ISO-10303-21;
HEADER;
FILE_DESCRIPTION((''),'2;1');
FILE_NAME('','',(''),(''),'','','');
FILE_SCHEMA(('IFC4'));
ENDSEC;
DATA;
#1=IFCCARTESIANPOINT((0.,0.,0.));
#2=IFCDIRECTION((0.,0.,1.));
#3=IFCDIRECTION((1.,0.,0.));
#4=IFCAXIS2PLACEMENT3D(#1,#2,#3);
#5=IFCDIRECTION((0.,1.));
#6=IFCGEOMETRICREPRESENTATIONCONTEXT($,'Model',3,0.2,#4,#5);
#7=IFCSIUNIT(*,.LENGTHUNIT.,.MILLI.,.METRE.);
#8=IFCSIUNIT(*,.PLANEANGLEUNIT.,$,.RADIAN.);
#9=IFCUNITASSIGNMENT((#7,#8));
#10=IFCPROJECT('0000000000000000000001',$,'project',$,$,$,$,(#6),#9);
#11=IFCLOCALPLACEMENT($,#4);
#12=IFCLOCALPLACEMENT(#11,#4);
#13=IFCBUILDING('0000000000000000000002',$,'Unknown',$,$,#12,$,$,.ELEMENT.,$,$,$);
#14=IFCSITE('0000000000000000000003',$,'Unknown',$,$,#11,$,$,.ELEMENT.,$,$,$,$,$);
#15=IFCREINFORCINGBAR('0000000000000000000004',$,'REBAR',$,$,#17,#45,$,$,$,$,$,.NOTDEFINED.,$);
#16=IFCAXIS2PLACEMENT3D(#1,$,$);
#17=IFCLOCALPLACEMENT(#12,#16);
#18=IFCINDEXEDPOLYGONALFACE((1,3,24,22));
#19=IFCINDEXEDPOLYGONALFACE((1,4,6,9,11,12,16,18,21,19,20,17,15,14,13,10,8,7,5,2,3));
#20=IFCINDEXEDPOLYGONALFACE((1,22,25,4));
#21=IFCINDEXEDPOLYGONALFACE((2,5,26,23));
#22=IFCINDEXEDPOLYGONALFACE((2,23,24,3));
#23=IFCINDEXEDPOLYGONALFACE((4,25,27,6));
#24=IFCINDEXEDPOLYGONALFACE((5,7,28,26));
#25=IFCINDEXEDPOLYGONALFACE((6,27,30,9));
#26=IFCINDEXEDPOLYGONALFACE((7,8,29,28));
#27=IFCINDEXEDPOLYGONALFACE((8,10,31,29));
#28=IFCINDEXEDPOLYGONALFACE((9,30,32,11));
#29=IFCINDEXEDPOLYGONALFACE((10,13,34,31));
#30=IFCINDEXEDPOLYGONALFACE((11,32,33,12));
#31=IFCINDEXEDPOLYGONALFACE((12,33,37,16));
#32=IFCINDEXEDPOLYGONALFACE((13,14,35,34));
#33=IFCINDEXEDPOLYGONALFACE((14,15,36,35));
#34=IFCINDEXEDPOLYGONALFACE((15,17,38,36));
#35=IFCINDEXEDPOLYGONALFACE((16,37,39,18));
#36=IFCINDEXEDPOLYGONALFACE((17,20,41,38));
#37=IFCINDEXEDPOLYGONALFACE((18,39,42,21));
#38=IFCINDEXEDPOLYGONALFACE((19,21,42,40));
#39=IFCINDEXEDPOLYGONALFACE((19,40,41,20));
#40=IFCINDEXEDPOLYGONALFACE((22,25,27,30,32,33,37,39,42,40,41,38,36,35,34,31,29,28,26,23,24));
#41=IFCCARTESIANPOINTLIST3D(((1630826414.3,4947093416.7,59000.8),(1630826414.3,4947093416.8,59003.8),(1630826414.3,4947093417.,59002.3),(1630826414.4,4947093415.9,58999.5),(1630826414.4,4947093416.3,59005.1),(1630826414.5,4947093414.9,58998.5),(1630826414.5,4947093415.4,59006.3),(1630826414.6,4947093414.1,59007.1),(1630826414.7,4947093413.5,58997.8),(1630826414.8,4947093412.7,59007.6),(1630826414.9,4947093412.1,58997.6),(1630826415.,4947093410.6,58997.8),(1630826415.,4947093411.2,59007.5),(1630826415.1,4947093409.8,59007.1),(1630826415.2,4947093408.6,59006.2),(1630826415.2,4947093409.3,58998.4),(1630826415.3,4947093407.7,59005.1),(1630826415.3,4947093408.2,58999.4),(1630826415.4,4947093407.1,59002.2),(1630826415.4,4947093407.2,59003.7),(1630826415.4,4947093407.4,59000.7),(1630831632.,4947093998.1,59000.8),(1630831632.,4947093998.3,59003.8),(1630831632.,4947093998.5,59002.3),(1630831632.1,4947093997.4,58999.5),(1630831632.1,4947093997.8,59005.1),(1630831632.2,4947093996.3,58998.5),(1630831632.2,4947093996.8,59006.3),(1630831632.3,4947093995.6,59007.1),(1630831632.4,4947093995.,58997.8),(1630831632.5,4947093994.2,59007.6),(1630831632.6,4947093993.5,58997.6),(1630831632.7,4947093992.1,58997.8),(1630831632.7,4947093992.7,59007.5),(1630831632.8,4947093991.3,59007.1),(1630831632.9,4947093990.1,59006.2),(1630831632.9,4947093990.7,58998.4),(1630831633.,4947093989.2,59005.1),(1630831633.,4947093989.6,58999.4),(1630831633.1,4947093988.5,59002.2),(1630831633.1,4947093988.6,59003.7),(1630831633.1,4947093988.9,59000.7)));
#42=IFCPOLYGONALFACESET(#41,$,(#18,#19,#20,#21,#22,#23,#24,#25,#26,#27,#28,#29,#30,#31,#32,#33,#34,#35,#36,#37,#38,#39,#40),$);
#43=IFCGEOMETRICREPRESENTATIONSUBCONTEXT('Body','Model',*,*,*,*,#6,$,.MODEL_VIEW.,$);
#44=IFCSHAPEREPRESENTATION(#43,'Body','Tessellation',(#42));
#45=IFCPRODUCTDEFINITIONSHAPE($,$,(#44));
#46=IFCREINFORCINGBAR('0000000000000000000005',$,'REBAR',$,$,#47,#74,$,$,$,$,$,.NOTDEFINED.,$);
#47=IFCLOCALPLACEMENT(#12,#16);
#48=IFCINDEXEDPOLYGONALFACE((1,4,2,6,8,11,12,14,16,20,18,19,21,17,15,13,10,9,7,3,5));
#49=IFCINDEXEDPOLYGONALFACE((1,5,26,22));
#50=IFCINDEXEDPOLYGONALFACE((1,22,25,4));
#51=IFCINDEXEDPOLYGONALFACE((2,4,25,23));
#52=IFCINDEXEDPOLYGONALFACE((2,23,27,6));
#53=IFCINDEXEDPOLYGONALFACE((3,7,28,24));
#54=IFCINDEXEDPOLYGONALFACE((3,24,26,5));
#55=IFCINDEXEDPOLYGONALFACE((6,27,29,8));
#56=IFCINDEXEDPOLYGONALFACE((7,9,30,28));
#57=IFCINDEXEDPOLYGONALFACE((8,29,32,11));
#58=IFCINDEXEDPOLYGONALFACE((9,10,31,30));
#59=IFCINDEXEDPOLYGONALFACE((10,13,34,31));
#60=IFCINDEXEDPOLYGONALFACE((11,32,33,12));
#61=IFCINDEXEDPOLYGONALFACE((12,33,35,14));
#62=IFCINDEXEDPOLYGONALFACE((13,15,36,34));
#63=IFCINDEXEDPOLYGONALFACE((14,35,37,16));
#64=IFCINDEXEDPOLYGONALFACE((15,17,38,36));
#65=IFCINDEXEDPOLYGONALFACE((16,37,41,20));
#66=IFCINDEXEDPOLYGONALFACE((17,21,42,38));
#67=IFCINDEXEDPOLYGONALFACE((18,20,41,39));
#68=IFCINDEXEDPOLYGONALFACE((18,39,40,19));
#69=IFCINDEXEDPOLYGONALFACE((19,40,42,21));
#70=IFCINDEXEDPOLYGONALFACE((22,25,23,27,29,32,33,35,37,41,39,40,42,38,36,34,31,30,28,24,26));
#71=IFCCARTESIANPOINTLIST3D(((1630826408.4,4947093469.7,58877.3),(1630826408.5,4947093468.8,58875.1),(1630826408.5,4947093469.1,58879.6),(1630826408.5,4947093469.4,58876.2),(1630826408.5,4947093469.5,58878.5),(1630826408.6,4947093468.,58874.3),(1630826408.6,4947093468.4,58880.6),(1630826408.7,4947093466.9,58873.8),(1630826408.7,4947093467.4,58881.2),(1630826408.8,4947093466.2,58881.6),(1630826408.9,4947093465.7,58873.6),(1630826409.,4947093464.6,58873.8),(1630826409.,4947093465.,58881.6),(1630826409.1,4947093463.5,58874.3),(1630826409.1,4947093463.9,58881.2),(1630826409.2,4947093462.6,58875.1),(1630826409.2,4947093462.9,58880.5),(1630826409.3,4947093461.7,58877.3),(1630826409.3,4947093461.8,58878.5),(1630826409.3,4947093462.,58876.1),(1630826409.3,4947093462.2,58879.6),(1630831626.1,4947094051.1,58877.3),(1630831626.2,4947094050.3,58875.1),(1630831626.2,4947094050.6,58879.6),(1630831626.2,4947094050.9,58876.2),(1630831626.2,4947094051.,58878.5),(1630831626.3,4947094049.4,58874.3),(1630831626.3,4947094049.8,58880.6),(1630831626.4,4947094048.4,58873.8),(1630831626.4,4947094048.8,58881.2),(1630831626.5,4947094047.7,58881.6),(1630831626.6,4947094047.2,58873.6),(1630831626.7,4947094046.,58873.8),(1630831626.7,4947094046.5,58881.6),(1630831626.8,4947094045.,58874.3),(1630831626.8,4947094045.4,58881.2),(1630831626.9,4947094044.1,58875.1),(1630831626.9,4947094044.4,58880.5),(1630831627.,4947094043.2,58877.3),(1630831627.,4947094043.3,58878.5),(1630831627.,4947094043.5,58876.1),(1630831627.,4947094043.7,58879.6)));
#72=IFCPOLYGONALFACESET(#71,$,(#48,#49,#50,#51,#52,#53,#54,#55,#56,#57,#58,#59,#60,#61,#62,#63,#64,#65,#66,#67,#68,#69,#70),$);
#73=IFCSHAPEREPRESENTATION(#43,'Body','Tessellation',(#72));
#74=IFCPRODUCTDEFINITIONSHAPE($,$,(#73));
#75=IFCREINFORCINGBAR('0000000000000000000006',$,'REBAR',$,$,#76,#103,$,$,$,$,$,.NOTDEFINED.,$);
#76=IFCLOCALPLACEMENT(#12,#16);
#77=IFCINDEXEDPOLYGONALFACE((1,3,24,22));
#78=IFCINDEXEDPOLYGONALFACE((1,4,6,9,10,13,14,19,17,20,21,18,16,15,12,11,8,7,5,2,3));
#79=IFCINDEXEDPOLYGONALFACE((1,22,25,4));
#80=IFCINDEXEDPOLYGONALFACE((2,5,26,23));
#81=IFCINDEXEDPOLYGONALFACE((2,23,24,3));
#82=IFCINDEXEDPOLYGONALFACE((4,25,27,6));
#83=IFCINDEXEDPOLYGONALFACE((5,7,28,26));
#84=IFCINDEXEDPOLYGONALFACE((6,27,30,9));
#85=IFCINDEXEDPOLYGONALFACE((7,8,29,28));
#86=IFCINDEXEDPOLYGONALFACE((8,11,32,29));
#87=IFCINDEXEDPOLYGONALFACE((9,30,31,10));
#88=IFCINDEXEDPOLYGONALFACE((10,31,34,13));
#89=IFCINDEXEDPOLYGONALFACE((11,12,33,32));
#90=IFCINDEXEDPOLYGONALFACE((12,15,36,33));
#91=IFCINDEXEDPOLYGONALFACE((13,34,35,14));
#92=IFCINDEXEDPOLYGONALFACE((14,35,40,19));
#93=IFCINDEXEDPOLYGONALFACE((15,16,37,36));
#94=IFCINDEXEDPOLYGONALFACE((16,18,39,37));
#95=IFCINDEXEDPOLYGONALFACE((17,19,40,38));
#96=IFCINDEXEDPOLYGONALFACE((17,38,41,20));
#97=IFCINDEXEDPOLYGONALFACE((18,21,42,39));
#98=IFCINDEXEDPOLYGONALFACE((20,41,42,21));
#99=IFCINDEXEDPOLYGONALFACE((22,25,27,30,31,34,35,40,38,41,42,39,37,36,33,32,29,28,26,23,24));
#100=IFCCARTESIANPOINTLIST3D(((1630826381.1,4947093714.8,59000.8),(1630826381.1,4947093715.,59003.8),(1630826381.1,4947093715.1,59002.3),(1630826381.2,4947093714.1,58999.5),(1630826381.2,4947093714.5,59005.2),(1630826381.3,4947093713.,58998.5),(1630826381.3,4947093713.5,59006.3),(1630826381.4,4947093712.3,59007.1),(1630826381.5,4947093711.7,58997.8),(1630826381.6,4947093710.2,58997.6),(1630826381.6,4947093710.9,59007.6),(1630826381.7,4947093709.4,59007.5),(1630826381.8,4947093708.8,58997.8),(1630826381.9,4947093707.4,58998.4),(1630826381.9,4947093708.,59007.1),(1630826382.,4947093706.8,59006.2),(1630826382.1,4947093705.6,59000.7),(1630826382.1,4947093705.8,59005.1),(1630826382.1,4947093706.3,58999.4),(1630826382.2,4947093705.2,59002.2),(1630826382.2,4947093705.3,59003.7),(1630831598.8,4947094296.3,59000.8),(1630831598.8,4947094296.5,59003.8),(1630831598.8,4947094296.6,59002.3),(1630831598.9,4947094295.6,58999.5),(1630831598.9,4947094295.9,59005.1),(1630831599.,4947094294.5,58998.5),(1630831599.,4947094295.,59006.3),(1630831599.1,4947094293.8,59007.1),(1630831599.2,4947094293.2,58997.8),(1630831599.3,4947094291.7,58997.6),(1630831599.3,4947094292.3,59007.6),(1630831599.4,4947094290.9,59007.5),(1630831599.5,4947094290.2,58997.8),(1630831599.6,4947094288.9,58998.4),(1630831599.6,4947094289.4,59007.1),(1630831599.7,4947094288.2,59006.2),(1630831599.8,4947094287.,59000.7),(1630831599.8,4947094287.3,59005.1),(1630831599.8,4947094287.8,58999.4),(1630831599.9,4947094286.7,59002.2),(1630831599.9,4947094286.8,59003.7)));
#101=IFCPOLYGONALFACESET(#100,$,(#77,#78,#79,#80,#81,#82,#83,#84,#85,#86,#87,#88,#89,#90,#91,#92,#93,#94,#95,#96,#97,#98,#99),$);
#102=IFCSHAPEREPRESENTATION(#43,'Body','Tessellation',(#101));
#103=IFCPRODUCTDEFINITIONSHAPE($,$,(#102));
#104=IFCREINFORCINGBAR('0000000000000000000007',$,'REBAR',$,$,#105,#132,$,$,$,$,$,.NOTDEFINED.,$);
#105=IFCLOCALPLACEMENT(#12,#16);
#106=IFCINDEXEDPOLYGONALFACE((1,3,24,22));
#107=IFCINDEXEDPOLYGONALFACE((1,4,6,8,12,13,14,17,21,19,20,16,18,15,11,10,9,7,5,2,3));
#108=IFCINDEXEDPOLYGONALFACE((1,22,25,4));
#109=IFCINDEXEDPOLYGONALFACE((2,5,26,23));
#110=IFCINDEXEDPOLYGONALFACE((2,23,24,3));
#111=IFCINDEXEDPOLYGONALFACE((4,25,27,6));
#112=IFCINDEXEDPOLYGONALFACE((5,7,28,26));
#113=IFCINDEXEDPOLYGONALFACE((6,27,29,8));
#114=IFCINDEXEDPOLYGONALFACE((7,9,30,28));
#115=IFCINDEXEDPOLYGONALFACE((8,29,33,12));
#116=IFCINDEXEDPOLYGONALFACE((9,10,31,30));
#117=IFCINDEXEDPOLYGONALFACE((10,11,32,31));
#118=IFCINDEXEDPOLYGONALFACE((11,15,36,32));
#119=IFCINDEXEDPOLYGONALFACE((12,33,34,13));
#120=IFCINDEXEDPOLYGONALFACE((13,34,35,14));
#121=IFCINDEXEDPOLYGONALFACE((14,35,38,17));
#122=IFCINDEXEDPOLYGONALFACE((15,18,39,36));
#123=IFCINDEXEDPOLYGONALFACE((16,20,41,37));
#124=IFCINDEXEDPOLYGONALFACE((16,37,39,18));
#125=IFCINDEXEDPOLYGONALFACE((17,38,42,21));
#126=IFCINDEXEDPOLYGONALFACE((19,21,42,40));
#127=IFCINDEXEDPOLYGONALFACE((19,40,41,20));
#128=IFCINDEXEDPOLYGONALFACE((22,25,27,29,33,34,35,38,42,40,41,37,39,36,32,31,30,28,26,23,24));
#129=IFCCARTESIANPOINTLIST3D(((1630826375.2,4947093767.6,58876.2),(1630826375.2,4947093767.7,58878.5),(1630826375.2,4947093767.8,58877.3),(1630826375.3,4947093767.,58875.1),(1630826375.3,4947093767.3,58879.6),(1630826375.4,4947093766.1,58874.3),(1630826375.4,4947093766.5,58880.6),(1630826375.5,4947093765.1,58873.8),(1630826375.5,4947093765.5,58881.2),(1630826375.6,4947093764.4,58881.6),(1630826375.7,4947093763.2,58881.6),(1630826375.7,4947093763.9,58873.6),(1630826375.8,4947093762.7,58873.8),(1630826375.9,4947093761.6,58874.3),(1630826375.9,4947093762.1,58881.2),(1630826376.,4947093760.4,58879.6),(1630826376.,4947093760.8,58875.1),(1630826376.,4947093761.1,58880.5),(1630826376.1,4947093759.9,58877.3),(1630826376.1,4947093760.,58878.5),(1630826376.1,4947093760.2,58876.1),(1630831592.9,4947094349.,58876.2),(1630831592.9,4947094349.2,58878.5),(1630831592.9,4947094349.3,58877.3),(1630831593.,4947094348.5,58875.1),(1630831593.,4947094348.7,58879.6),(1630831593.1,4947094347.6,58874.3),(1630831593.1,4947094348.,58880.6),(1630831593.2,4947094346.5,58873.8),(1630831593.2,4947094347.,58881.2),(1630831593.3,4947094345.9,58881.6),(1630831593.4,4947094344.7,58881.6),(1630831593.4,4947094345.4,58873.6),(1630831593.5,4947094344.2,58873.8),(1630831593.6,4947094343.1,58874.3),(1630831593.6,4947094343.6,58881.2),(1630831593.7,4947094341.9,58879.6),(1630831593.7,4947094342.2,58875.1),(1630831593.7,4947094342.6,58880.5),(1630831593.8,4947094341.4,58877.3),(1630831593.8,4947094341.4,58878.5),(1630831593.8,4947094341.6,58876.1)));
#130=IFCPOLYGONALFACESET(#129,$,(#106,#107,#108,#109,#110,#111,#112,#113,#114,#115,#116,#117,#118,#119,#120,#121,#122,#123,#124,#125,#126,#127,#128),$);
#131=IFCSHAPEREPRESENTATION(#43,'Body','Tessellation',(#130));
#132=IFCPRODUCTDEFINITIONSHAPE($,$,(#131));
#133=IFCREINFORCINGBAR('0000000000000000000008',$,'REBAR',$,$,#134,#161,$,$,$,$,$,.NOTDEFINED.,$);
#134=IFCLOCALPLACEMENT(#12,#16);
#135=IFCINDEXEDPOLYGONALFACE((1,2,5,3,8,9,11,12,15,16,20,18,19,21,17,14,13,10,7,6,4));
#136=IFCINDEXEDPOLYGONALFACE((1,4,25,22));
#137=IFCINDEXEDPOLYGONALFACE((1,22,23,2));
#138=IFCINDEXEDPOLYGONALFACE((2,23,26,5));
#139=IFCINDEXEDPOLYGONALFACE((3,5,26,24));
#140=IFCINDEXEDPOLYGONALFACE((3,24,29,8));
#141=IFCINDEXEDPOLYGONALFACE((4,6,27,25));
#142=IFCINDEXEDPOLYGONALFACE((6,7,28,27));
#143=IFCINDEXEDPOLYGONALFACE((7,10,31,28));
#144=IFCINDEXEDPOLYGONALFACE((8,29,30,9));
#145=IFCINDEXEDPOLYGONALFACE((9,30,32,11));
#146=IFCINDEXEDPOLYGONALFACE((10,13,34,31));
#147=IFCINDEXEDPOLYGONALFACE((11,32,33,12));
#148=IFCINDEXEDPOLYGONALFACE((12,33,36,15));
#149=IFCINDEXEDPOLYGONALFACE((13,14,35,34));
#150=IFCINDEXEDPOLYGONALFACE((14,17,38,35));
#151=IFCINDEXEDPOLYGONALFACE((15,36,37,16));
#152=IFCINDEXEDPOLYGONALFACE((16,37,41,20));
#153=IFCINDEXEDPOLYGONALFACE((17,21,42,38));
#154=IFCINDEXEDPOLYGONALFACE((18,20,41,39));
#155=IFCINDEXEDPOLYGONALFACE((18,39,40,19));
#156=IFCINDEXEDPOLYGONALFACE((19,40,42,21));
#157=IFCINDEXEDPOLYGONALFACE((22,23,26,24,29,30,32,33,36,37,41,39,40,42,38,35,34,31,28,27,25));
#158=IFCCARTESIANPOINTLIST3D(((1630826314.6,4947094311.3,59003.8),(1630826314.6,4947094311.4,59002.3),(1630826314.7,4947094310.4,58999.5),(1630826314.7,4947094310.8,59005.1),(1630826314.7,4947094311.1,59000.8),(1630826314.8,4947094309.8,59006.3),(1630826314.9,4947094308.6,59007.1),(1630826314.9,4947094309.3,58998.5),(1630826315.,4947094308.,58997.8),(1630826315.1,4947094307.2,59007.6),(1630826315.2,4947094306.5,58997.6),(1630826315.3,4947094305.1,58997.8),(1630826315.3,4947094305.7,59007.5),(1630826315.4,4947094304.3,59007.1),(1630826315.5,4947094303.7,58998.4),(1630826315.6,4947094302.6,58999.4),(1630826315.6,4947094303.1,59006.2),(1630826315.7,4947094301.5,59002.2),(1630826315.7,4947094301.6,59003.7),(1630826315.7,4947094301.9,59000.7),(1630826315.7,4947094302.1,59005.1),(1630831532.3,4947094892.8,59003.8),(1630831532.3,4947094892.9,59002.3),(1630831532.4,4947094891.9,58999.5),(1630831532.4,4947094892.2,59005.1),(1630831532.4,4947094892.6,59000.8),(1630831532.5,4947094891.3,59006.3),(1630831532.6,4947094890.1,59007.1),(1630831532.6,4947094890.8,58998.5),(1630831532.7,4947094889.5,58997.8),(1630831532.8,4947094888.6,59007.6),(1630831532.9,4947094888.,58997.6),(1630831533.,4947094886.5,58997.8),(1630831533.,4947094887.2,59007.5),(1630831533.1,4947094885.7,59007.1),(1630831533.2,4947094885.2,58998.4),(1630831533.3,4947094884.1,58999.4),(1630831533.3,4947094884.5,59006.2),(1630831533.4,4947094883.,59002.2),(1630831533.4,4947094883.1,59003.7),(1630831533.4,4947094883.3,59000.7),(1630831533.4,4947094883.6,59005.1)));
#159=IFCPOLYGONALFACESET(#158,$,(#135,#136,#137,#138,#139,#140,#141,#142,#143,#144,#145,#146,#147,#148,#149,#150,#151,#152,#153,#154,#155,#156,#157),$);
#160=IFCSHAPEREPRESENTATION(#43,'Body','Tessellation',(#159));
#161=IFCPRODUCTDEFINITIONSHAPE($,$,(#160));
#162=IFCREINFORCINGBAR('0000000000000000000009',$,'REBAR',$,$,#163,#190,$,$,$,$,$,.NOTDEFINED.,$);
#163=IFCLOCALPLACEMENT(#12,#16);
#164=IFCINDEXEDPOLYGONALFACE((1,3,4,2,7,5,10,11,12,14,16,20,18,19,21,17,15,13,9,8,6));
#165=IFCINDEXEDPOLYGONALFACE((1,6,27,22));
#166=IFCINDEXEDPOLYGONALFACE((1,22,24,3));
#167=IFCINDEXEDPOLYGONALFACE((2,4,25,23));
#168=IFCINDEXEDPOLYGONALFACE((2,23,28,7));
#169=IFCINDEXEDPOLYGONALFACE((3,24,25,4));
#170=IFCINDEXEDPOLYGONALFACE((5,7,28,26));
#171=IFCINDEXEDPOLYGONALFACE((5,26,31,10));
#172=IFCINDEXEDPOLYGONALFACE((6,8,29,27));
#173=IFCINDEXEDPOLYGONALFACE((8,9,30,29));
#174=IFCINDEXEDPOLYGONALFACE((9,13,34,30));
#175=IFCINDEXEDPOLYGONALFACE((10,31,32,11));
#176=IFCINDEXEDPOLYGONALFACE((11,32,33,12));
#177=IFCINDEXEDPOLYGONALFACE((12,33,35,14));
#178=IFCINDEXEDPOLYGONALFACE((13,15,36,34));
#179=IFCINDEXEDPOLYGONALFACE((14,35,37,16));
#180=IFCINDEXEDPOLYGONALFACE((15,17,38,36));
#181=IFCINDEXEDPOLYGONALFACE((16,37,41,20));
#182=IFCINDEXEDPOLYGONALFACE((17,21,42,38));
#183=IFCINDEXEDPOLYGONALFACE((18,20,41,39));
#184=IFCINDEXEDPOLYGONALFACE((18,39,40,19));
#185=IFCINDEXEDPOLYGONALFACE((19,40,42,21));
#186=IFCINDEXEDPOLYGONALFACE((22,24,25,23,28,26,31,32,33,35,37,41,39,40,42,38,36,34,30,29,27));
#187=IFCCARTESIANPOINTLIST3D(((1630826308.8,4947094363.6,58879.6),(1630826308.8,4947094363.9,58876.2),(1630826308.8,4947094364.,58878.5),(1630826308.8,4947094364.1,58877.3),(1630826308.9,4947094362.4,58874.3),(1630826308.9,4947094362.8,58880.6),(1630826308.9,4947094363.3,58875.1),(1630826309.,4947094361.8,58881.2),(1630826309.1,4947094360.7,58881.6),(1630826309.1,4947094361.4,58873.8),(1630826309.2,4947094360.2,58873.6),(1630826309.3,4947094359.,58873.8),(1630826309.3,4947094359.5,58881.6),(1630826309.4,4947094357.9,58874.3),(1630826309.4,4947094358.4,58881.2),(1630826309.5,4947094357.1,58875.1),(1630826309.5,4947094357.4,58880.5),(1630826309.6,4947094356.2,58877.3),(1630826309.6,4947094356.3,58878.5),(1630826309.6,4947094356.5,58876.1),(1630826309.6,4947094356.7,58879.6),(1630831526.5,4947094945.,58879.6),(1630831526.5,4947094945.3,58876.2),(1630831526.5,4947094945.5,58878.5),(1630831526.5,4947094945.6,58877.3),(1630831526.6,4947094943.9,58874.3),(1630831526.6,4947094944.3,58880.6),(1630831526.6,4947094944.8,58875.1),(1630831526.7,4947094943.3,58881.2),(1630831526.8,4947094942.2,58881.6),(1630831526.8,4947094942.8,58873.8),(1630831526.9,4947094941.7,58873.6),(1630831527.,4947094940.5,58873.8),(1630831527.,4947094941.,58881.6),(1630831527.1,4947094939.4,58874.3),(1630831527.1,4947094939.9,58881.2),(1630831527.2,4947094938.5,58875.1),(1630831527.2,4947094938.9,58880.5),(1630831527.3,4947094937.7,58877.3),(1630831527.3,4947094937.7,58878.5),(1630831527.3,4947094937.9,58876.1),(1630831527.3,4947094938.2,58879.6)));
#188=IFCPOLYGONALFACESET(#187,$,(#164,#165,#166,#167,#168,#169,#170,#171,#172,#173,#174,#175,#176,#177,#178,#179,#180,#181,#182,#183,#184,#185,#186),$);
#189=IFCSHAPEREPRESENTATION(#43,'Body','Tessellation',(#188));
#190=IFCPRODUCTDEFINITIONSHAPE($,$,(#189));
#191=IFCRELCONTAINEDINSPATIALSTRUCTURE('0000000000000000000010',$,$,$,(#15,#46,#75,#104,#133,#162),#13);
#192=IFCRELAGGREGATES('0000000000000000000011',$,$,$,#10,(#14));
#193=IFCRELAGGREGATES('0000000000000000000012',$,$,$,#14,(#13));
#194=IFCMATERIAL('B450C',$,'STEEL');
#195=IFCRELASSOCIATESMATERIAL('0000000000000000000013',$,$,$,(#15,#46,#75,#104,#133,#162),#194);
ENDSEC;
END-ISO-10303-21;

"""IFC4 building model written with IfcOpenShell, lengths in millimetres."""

from ifc_helpers import new_model, entity, si_unit, direction, frame, origin_with_axes, place, context, subcontext, project, spatial, material, element, save


model = new_model("IFC4")

# Units and contexts
model_context = context("Model", 3, precision=0.2, world=origin_with_axes(), true_north=direction((0.0, 1.0)))
body_context = subcontext(model_context, "Body", "Model", "MODEL_VIEW")
ifc_project = project(units=[si_unit("LENGTHUNIT", "METRE", prefix="MILLI"), si_unit("PLANEANGLEUNIT", "RADIAN")], contexts=[model_context])

# Site, building
site_placement = place(None, origin_with_axes())
site = spatial("IfcSite", under=ifc_project, at=site_placement, Name="Unknown", CompositionType="ELEMENT")
building_placement = place(site_placement, origin_with_axes())
building = spatial("IfcBuilding", under=site, at=building_placement, Name="Unknown", CompositionType="ELEMENT")

# Reinforcing bars
ifc_material = material(Name="B450C", Category="STEEL")
reinforcing_bar_1_placement = place(building_placement, frame((1630831632.6, 4947093993.5, 59002.6), z_axis=(0.007106, -0.063762, -0.99794), x_axis=(-0.993847, -0.110757, 0.0)))
element("IfcReinforcingBar", 1, at=reinforcing_bar_1_placement, inside=building, material=ifc_material, Name="REBAR", PredefinedType="NOTDEFINED", context=body_context, shape_type="AdvancedSweptSolid", body=[
    entity("IfcSweptDiskSolid", entity("IfcIndexedPolyCurve", entity("IfcCartesianPointList3D", [[0.0, 0.0, 0.0], [5250.0, 0.0, 0.0]]), [entity("IfcLineIndex", [1, 2])]), 5.0),
])
reinforcing_bar_2_placement = place(building_placement, frame((1630831626.6, 4947094047.2, 58877.6), z_axis=(0.007106, -0.063762, -0.99794), x_axis=(-0.993847, -0.110757, 0.0)))
element("IfcReinforcingBar", 2, at=reinforcing_bar_2_placement, inside=building, material=ifc_material, Name="REBAR", PredefinedType="NOTDEFINED", context=body_context, shape_type="AdvancedSweptSolid", body=[
    entity("IfcSweptDiskSolid", entity("IfcIndexedPolyCurve", entity("IfcCartesianPointList3D", [[0.0, 0.0, 0.0], [5250.0, 0.0, 0.0]]), [entity("IfcLineIndex", [1, 2])]), 4.0),
])
reinforcing_bar_3_placement = place(building_placement, frame((1630831599.3, 4947094291.6, 59002.6), z_axis=(0.007106, -0.063762, -0.99794), x_axis=(-0.993847, -0.110757, 0.0)))
element("IfcReinforcingBar", 3, at=reinforcing_bar_3_placement, inside=building, material=ifc_material, Name="REBAR", PredefinedType="NOTDEFINED", context=body_context, shape_type="AdvancedSweptSolid", body=[
    entity("IfcSweptDiskSolid", entity("IfcIndexedPolyCurve", entity("IfcCartesianPointList3D", [[0.0, 0.0, 0.0], [5250.0, 0.0, 0.0]]), [entity("IfcLineIndex", [1, 2])]), 5.0),
])
reinforcing_bar_4_placement = place(building_placement, frame((1630831593.4, 4947094345.3, 58877.6), z_axis=(0.007106, -0.063762, -0.99794), x_axis=(-0.993847, -0.110757, 0.0)))
element("IfcReinforcingBar", 4, at=reinforcing_bar_4_placement, inside=building, material=ifc_material, Name="REBAR", PredefinedType="NOTDEFINED", context=body_context, shape_type="AdvancedSweptSolid", body=[
    entity("IfcSweptDiskSolid", entity("IfcIndexedPolyCurve", entity("IfcCartesianPointList3D", [[0.0, 0.0, 0.0], [5250.0, 0.0, 0.0]]), [entity("IfcLineIndex", [1, 2])]), 4.0),
])
reinforcing_bar_5_placement = place(building_placement, frame((1630831532.9, 4947094888.0, 59002.6), z_axis=(0.007106, -0.063762, -0.99794), x_axis=(-0.993847, -0.110757, 0.0)))
element("IfcReinforcingBar", 5, at=reinforcing_bar_5_placement, inside=building, material=ifc_material, Name="REBAR", PredefinedType="NOTDEFINED", context=body_context, shape_type="AdvancedSweptSolid", body=[
    entity("IfcSweptDiskSolid", entity("IfcIndexedPolyCurve", entity("IfcCartesianPointList3D", [[0.0, 0.0, 0.0], [5250.0, 0.0, 0.0]]), [entity("IfcLineIndex", [1, 2])]), 5.0),
])
reinforcing_bar_6_placement = place(building_placement, frame((1630831526.9, 4947094941.6, 58877.6), z_axis=(0.007106, -0.063762, -0.99794), x_axis=(-0.993847, -0.110757, 0.0)))
element("IfcReinforcingBar", 6, at=reinforcing_bar_6_placement, inside=building, material=ifc_material, Name="REBAR", PredefinedType="NOTDEFINED", context=body_context, shape_type="AdvancedSweptSolid", body=[
    entity("IfcSweptDiskSolid", entity("IfcIndexedPolyCurve", entity("IfcCartesianPointList3D", [[0.0, 0.0, 0.0], [5250.0, 0.0, 0.0]]), [entity("IfcLineIndex", [1, 2])]), 4.0),
])

save(model, "model.ifc")
